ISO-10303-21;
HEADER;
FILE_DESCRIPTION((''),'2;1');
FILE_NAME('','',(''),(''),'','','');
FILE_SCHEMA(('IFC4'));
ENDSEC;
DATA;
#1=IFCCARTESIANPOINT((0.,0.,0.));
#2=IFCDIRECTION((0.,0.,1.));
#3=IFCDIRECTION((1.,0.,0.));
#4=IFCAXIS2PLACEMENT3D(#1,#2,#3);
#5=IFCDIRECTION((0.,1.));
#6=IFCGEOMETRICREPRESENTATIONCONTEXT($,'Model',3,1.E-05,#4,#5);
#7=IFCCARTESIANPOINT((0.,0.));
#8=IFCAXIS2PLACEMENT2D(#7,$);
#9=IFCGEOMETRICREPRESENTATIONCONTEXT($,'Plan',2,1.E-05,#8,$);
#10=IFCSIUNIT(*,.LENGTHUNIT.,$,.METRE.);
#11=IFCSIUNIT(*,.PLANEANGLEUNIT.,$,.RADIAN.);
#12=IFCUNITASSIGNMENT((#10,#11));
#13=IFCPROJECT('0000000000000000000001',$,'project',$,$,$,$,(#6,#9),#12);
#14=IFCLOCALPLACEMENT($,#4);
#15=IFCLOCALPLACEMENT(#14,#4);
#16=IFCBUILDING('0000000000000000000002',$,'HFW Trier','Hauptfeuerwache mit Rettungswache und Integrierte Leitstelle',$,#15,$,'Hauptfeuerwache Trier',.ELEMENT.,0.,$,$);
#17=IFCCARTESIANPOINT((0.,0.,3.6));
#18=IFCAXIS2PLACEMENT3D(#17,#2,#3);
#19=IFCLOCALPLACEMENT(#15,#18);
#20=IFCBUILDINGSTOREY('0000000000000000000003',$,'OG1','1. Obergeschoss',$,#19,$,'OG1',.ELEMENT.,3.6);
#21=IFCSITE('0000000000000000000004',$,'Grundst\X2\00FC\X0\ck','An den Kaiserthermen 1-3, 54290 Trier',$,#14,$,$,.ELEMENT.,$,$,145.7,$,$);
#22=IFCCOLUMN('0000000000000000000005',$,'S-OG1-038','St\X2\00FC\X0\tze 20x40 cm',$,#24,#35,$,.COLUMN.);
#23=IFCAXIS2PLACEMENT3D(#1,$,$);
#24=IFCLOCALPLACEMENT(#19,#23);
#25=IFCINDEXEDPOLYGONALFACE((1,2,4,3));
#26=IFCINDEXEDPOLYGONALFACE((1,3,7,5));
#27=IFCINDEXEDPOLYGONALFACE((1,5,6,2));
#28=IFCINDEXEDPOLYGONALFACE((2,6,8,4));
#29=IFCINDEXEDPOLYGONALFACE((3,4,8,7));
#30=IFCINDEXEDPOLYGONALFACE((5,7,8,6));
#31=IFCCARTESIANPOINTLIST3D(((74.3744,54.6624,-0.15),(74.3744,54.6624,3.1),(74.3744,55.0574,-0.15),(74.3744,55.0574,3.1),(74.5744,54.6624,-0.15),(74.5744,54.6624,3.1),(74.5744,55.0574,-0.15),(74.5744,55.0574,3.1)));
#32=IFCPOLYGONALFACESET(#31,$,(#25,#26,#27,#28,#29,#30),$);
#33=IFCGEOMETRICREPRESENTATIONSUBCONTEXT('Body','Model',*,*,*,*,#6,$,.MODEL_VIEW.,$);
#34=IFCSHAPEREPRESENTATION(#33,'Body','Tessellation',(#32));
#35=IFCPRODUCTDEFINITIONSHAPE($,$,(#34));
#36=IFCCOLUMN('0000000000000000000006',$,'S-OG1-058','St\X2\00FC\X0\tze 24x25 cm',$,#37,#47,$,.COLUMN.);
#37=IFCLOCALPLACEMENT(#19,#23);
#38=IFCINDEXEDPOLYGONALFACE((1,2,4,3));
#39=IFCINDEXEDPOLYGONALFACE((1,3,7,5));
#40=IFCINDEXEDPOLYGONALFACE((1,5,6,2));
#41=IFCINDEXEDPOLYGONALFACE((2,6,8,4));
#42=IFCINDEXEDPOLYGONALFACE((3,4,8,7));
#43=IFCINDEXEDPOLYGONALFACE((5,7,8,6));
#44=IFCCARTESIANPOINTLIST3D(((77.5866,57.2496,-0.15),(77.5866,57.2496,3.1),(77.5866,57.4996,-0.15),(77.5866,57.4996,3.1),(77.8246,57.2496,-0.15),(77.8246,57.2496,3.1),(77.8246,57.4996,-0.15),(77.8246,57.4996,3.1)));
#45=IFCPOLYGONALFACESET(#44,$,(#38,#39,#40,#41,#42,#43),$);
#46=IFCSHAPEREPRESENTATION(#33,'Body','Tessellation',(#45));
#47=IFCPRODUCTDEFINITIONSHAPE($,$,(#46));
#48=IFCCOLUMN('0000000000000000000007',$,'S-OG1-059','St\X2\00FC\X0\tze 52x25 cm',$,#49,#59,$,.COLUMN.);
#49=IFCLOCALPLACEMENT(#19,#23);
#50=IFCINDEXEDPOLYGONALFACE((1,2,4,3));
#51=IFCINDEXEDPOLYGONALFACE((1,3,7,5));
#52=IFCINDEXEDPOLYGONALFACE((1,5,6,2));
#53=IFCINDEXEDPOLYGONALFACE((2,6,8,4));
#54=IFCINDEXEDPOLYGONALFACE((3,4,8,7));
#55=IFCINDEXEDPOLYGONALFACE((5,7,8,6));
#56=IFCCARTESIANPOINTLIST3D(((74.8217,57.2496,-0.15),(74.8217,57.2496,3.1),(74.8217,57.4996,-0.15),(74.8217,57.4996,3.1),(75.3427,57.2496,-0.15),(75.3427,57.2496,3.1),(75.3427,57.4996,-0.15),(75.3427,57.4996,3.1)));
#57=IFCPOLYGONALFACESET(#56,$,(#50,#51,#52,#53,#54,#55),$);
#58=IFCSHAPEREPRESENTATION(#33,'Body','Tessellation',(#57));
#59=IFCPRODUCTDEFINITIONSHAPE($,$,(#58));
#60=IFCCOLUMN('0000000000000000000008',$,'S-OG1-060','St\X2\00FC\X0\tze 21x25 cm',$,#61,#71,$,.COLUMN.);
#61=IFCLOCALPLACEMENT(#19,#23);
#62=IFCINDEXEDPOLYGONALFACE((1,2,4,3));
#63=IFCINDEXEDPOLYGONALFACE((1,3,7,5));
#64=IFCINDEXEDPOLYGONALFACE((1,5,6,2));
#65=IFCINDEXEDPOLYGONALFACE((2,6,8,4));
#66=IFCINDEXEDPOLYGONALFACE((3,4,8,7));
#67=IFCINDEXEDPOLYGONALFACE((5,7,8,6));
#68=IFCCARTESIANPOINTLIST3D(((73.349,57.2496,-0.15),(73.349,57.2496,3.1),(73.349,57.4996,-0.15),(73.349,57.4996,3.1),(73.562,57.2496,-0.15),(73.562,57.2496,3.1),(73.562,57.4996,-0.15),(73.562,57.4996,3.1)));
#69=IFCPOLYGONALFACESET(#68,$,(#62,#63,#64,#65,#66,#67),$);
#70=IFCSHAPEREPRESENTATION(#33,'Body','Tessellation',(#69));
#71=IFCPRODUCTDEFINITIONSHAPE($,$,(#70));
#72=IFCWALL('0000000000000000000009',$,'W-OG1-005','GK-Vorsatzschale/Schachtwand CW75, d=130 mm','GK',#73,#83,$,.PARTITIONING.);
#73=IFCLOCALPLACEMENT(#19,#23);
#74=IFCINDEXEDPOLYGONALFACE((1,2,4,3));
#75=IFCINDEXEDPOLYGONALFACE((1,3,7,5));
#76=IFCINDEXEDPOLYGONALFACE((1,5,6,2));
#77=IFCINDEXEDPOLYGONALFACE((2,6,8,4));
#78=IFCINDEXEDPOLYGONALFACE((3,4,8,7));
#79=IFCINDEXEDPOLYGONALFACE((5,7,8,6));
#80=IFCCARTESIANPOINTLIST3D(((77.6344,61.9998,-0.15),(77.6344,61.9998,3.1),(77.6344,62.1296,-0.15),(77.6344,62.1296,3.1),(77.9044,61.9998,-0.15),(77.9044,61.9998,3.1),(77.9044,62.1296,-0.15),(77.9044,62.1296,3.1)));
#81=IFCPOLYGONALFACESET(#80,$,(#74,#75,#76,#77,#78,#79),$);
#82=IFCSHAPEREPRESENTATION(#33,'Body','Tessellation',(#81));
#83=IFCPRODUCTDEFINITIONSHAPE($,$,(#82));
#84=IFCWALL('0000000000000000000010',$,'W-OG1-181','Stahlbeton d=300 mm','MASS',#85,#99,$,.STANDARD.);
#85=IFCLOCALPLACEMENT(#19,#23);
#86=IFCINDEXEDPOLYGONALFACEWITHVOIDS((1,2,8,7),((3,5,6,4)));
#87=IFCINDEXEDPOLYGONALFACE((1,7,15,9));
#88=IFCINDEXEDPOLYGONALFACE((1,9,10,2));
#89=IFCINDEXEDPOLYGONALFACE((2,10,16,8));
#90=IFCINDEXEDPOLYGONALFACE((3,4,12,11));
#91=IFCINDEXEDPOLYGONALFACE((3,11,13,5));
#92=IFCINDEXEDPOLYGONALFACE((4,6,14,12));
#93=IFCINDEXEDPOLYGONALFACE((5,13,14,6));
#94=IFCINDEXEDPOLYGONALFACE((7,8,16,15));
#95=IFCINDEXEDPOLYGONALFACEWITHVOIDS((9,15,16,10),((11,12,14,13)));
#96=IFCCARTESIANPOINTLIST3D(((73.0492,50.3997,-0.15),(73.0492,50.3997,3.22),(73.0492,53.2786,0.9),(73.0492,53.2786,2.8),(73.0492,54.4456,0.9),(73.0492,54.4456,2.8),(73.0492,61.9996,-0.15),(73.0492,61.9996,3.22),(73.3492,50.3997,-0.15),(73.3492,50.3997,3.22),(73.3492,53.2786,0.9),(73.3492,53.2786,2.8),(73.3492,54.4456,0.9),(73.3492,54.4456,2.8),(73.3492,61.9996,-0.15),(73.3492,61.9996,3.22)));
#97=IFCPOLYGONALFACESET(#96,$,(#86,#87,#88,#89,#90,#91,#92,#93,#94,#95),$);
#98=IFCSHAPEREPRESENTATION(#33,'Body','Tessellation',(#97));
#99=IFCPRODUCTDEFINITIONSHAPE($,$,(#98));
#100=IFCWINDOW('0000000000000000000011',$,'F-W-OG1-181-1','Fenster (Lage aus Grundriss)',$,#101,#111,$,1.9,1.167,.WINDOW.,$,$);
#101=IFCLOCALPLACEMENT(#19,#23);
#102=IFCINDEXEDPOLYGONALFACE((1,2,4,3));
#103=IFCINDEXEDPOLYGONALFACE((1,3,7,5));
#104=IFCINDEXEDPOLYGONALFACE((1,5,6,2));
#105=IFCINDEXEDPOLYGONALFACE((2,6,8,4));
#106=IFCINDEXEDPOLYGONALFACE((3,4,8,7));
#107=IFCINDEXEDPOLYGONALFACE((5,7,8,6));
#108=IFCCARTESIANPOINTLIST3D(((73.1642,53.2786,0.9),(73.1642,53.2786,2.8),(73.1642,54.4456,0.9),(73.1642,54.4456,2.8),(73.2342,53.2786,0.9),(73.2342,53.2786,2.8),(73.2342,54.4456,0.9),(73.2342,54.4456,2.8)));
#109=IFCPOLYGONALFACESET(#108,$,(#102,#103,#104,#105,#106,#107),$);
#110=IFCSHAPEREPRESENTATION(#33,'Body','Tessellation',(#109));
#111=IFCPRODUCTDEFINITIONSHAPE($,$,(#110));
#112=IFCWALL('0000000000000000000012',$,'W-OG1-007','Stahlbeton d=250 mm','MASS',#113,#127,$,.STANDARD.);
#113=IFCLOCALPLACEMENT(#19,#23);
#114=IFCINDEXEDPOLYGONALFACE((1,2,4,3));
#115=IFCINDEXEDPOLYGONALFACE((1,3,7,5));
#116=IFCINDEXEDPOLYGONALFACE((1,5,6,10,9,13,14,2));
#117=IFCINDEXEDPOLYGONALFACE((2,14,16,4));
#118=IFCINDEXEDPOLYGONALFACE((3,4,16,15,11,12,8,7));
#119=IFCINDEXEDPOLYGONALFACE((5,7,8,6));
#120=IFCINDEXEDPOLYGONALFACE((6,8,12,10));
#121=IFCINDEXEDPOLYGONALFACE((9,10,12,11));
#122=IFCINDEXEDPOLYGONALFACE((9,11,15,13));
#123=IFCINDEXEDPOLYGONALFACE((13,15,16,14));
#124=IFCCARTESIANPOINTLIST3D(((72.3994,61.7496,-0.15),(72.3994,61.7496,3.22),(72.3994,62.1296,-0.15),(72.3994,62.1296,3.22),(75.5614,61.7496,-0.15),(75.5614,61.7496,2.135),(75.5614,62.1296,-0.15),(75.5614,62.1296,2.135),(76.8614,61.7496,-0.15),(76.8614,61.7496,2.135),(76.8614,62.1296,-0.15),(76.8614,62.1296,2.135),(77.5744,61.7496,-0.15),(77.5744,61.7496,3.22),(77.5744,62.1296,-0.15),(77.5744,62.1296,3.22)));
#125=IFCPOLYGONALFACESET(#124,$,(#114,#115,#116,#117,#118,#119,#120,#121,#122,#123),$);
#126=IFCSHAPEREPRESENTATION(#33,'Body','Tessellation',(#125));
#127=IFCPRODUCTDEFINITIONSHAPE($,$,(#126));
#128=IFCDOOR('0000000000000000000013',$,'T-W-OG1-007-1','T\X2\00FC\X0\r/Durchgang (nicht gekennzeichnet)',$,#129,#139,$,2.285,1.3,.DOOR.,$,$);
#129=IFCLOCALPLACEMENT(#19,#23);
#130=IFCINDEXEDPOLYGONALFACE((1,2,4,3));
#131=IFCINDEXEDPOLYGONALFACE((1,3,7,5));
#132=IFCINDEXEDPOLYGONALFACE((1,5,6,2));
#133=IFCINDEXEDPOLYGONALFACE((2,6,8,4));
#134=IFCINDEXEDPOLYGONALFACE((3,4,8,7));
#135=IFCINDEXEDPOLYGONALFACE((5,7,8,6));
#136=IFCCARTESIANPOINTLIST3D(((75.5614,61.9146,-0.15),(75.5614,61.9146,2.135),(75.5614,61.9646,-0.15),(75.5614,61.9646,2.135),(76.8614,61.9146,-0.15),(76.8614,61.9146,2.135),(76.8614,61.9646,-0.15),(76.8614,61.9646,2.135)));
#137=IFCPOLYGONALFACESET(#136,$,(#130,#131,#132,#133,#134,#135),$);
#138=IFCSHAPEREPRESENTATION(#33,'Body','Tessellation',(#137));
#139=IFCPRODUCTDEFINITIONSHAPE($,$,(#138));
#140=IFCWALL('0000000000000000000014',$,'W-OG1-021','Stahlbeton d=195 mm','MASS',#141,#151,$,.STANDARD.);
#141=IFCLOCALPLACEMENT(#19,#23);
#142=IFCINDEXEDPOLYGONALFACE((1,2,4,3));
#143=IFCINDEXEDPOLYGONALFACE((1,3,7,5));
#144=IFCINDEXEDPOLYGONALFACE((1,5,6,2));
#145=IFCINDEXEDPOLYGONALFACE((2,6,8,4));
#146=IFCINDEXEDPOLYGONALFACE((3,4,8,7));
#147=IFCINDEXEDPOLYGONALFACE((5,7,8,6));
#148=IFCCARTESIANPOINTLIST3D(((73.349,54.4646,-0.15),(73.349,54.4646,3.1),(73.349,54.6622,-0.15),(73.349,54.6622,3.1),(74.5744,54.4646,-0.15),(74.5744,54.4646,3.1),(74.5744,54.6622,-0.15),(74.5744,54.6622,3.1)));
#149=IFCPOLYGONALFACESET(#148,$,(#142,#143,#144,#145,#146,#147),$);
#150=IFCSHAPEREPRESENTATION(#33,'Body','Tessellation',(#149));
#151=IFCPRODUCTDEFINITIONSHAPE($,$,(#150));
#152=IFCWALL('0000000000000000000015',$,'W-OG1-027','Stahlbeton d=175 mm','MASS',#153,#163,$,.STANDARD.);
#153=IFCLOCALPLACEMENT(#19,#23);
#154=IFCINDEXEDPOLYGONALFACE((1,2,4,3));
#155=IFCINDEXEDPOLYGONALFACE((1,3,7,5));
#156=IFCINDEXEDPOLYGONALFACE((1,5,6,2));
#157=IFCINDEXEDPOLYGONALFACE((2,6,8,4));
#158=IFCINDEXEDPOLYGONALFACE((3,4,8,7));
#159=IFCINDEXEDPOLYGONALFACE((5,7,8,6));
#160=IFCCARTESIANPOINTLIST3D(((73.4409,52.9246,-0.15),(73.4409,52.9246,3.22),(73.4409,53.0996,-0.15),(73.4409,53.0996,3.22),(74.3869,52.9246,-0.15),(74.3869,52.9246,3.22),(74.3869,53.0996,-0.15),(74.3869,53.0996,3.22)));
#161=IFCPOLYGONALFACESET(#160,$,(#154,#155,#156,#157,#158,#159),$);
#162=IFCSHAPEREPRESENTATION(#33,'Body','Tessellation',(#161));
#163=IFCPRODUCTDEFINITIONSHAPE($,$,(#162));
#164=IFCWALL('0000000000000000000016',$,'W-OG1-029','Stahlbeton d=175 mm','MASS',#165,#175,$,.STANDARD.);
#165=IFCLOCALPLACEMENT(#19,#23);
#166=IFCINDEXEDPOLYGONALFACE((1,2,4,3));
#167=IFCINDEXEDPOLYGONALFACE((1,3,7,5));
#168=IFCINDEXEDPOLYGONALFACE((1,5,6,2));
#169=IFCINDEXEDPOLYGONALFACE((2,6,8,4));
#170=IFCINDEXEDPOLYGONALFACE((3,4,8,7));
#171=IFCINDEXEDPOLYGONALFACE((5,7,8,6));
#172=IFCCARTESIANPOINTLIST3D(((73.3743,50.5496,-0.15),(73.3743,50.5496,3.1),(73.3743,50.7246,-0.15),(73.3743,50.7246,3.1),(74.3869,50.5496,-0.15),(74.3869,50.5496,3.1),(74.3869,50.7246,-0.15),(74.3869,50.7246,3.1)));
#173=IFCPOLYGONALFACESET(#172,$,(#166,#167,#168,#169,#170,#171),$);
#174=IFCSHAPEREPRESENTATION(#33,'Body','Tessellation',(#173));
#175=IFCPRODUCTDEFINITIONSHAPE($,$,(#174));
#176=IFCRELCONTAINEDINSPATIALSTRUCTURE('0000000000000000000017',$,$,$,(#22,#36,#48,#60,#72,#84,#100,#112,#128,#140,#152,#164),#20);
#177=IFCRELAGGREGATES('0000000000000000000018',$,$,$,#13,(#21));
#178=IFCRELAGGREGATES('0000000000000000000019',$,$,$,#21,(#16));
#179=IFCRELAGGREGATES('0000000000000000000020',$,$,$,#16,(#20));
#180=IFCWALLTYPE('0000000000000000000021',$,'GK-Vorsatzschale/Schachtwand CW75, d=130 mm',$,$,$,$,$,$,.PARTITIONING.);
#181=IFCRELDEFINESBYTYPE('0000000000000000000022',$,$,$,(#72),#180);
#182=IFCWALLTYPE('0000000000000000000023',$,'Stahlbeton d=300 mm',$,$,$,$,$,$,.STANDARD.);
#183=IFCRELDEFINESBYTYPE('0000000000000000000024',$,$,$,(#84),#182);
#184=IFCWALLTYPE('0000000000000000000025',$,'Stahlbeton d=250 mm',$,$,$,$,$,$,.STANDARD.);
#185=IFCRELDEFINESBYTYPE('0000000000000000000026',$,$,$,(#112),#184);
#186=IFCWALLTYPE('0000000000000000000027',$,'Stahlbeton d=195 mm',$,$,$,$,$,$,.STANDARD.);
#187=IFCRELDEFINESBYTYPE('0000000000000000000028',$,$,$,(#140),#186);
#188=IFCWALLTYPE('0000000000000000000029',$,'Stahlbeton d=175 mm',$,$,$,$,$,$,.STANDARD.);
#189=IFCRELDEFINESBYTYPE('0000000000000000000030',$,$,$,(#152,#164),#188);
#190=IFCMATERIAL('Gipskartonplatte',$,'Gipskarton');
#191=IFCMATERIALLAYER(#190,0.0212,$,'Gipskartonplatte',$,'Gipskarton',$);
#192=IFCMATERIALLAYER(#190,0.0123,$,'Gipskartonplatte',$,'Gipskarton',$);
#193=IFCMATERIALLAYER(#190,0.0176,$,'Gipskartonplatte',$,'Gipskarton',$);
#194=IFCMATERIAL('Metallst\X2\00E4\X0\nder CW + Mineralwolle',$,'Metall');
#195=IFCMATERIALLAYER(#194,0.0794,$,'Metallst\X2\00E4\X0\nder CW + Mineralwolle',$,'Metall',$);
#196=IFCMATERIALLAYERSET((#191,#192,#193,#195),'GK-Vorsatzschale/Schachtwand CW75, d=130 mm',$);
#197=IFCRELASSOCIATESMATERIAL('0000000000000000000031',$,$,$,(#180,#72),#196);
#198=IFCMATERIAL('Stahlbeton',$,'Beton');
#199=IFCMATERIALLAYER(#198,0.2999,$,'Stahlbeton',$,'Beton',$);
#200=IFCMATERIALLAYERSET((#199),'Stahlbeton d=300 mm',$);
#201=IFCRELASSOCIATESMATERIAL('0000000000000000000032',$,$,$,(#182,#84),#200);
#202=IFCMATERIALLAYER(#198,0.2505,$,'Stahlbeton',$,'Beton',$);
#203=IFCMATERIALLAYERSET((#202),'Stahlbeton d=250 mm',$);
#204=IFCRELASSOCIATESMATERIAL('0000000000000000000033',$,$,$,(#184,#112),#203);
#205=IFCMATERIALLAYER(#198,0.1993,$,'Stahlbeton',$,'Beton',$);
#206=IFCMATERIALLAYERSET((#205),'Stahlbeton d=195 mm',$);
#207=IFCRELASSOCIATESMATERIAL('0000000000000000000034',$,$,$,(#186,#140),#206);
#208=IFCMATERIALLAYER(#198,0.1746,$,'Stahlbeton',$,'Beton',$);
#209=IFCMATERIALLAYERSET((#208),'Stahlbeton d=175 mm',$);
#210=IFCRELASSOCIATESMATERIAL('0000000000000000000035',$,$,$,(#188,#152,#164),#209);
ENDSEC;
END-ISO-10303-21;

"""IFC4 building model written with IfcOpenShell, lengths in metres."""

from ifc_helpers import new_model, si_unit, direction, frame, frame_2d, origin_with_axes, origin_2d, place, context, subcontext, project, spatial, rectangle, extrude, material, layer, layer_set, layer_usage, type_object, element, fill, save


model = new_model("IFC4")

# Units and contexts
model_context = context("Model", 3, precision=1e-05, world=origin_with_axes(), true_north=direction((0.0, 1.0)))
plan_context = context("Plan", 2, precision=1e-05, world=origin_2d())
body_context = subcontext(model_context, "Body", "Model", "MODEL_VIEW")
ifc_project = project(units=[si_unit("LENGTHUNIT", "METRE"), si_unit("PLANEANGLEUNIT", "RADIAN")], contexts=[model_context, plan_context])

# Site, building, storey
site_placement = place(None, origin_with_axes())
site = spatial("IfcSite", under=ifc_project, at=site_placement, Name="Grundstück", Description="An den Kaiserthermen 1-3, 54290 Trier", CompositionType="ELEMENT", RefElevation=145.7)
building_placement = place(site_placement, origin_with_axes())
building = spatial("IfcBuilding", under=site, at=building_placement, Name="HFW Trier", Description="Hauptfeuerwache mit Rettungswache und Integrierte Leitstelle", LongName="Hauptfeuerwache Trier", CompositionType="ELEMENT", ElevationOfRefHeight=0.0)
storey_placement = place(building_placement, frame((0.0, 0.0, 3.6), z_axis=(0.0, 0.0, 1.0), x_axis=(1.0, 0.0, 0.0)))
storey = spatial("IfcBuildingStorey", under=building, at=storey_placement, Name="OG1", Description="1. Obergeschoss", LongName="OG1", CompositionType="ELEMENT", Elevation=3.6)

# Columns
column_1_placement = place(storey_placement, frame((74.3744, 54.8599, -0.15), z_axis=(0.0, 0.0, 1.0), x_axis=(1.0, 0.0, 0.0)))
element("IfcColumn", 1, at=column_1_placement, inside=storey, Name="S-OG1-038", Description="Stütze 20x40 cm", PredefinedType="COLUMN", context=body_context, shape_type="SweptSolid", body=[
    extrude(rectangle(XDim=0.2, YDim=0.395, at=frame_2d((0.1, 0.0))), origin_with_axes(), (0.0, 0.0, 1.0), 3.25),
])
column_2_placement = place(storey_placement, frame((77.5866, 57.3746, -0.15), z_axis=(0.0, 0.0, 1.0), x_axis=(1.0, 0.0, 0.0)))
element("IfcColumn", 2, at=column_2_placement, inside=storey, Name="S-OG1-058", Description="Stütze 24x25 cm", PredefinedType="COLUMN", context=body_context, shape_type="SweptSolid", body=[
    extrude(rectangle(XDim=0.238, YDim=0.25, at=frame_2d((0.119, 0.0))), origin_with_axes(), (0.0, 0.0, 1.0), 3.25),
])
column_3_placement = place(storey_placement, frame((74.8217, 57.3746, -0.15), z_axis=(0.0, 0.0, 1.0), x_axis=(1.0, 0.0, 0.0)))
element("IfcColumn", 3, at=column_3_placement, inside=storey, Name="S-OG1-059", Description="Stütze 52x25 cm", PredefinedType="COLUMN", context=body_context, shape_type="SweptSolid", body=[
    extrude(rectangle(XDim=0.521, YDim=0.25, at=frame_2d((0.2605, 0.0))), origin_with_axes(), (0.0, 0.0, 1.0), 3.25),
])
column_4_placement = place(storey_placement, frame((73.349, 57.3746, -0.15), z_axis=(0.0, 0.0, 1.0), x_axis=(1.0, 0.0, 0.0)))
element("IfcColumn", 4, at=column_4_placement, inside=storey, Name="S-OG1-060", Description="Stütze 21x25 cm", PredefinedType="COLUMN", context=body_context, shape_type="SweptSolid", body=[
    extrude(rectangle(XDim=0.213, YDim=0.25, at=frame_2d((0.1065, 0.0))), origin_with_axes(), (0.0, 0.0, 1.0), 3.25),
])

# Wall
ifc_material_1 = material(Name="Gipskartonplatte", Category="Gipskarton")
ifc_layer_1 = layer(ifc_material_1, 0.0212, Name="Gipskartonplatte", Category="Gipskarton")
ifc_layer_2 = layer(ifc_material_1, 0.0123, Name="Gipskartonplatte", Category="Gipskarton")
ifc_layer_3 = layer(ifc_material_1, 0.0176, Name="Gipskartonplatte", Category="Gipskarton")
ifc_material_2 = material(Name="Metallständer CW + Mineralwolle", Category="Metall")
ifc_layer_4 = layer(ifc_material_2, 0.0794, Name="Metallständer CW + Mineralwolle", Category="Metall")
ifc_layer_set_1 = layer_set([ifc_layer_1, ifc_layer_2, ifc_layer_3, ifc_layer_4], Name="GK-Vorsatzschale/Schachtwand CW75, d=130 mm")
ifc_layer_usage_1 = layer_usage(ifc_layer_set_1, "AXIS2", "POSITIVE", -0.0649)
wall_type_1 = type_object("IfcWallType", Name="GK-Vorsatzschale/Schachtwand CW75, d=130 mm", PredefinedType="PARTITIONING", material=ifc_layer_set_1)
wall_1_placement = place(storey_placement, frame((77.6344, 62.0647, -0.15), z_axis=(0.0, 0.0, 1.0), x_axis=(1.0, 0.0, 0.0)))
element("IfcWall", 5, at=wall_1_placement, inside=storey, type_object=wall_type_1, material=ifc_layer_usage_1, Name="W-OG1-005", Description="GK-Vorsatzschale/Schachtwand CW75, d=130 mm", ObjectType="GK", PredefinedType="PARTITIONING", context=body_context, shape_type="SweptSolid", body=[
    extrude(rectangle(XDim=0.27, YDim=0.1298, at=frame_2d((0.135, 0.0))), origin_with_axes(), (0.0, 0.0, 1.0), 3.25),
])

# Wall, opening, window
ifc_material_3 = material(Name="Stahlbeton", Category="Beton")
ifc_layer_5 = layer(ifc_material_3, 0.2999, Name="Stahlbeton", Category="Beton")
ifc_layer_set_2 = layer_set([ifc_layer_5], Name="Stahlbeton d=300 mm")
ifc_layer_usage_2 = layer_usage(ifc_layer_set_2, "AXIS2", "POSITIVE", -0.15)
wall_type_2 = type_object("IfcWallType", Name="Stahlbeton d=300 mm", PredefinedType="STANDARD", material=ifc_layer_set_2)
wall_2_placement = place(storey_placement, frame((73.1992, 61.9996, -0.15), z_axis=(0.0, 0.0, 1.0), x_axis=(0.0, -1.0, 0.0)))
wall_2 = element("IfcWall", 6, at=wall_2_placement, inside=storey, type_object=wall_type_2, material=ifc_layer_usage_2, Name="W-OG1-181", Description="Stahlbeton d=300 mm", ObjectType="MASS", PredefinedType="STANDARD", context=body_context, shape_type="SweptSolid", body=[
    extrude(rectangle(XDim=11.5999, YDim=0.3, at=frame_2d((5.7999, 0.0))), origin_with_axes(), (0.0, 0.0, 1.0), 3.37),
])
opening_1_placement = place(wall_2_placement, frame((7.554, 0.0, 0.0), z_axis=(0.0, 0.0, 1.0), x_axis=(1.0, 0.0, 0.0)))
opening_1 = element("IfcOpeningElement", 7, at=opening_1_placement, cuts=wall_2, PredefinedType="OPENING", context=body_context, shape_type="SweptSolid", body=[
    extrude(rectangle(XDim=1.167, YDim=0.4, at=frame_2d((0.5835, 0.0))), frame((0.0, 0.0, 1.05), z_axis=(0.0, 0.0, 1.0), x_axis=(1.0, 0.0, 0.0)), (0.0, 0.0, 1.0), 1.9),
])
window_placement = place(wall_2_placement, frame((7.554, 0.0, 0.0), z_axis=(0.0, 0.0, 1.0), x_axis=(1.0, 0.0, 0.0)))
window = element("IfcWindow", 8, at=window_placement, inside=storey, Name="F-W-OG1-181-1", Description="Fenster (Lage aus Grundriss)", OverallHeight=1.9, OverallWidth=1.167, PredefinedType="WINDOW", context=body_context, shape_type="SweptSolid", body=[
    extrude(rectangle(XDim=1.167, YDim=0.07, at=frame_2d((0.5835, 0.0))), frame((0.0, 0.0, 1.05), z_axis=(0.0, 0.0, 1.0), x_axis=(1.0, 0.0, 0.0)), (0.0, 0.0, 1.0), 1.9),
])
fill(opening_1, window)

# Wall, opening, door
ifc_layer_6 = layer(ifc_material_3, 0.2505, Name="Stahlbeton", Category="Beton")
ifc_layer_set_3 = layer_set([ifc_layer_6], Name="Stahlbeton d=250 mm")
ifc_layer_usage_3 = layer_usage(ifc_layer_set_3, "AXIS2", "POSITIVE", -0.19)
wall_type_3 = type_object("IfcWallType", Name="Stahlbeton d=250 mm", PredefinedType="STANDARD", material=ifc_layer_set_3)
wall_3_placement = place(storey_placement, frame((72.3994, 61.9396, -0.15), z_axis=(0.0, 0.0, 1.0), x_axis=(1.0, 0.0, 0.0)))
wall_3 = element("IfcWall", 9, at=wall_3_placement, inside=storey, type_object=wall_type_3, material=ifc_layer_usage_3, Name="W-OG1-007", Description="Stahlbeton d=250 mm", ObjectType="MASS", PredefinedType="STANDARD", context=body_context, shape_type="SweptSolid", body=[
    extrude(rectangle(XDim=5.175, YDim=0.38, at=frame_2d((2.5875, 0.0))), origin_with_axes(), (0.0, 0.0, 1.0), 3.37),
])
opening_2_placement = place(wall_3_placement, frame((3.162, 0.0, 0.0), z_axis=(0.0, 0.0, 1.0), x_axis=(1.0, 0.0, 0.0)))
opening_2 = element("IfcOpeningElement", 10, at=opening_2_placement, cuts=wall_3, PredefinedType="OPENING", context=body_context, shape_type="SweptSolid", body=[
    extrude(rectangle(XDim=1.3, YDim=0.48, at=frame_2d((0.65, 0.0))), origin_with_axes(), (0.0, 0.0, 1.0), 2.285),
])
door_placement = place(wall_3_placement, frame((3.162, 0.0, 0.0), z_axis=(0.0, 0.0, 1.0), x_axis=(1.0, 0.0, 0.0)))
door = element("IfcDoor", 11, at=door_placement, inside=storey, Name="T-W-OG1-007-1", Description="Tür/Durchgang (nicht gekennzeichnet)", OverallHeight=2.285, OverallWidth=1.3, PredefinedType="DOOR", context=body_context, shape_type="SweptSolid", body=[
    extrude(rectangle(XDim=1.3, YDim=0.05, at=frame_2d((0.65, 0.0))), origin_with_axes(), (0.0, 0.0, 1.0), 2.285),
])
fill(opening_2, door)

# Walls
ifc_layer_7 = layer(ifc_material_3, 0.1993, Name="Stahlbeton", Category="Beton")
ifc_layer_set_4 = layer_set([ifc_layer_7], Name="Stahlbeton d=195 mm")
ifc_layer_usage_4 = layer_usage(ifc_layer_set_4, "AXIS2", "POSITIVE", -0.0988)
wall_type_4 = type_object("IfcWallType", Name="Stahlbeton d=195 mm", PredefinedType="STANDARD", material=ifc_layer_set_4)
wall_4_placement = place(storey_placement, frame((73.349, 54.5634, -0.15), z_axis=(0.0, 0.0, 1.0), x_axis=(1.0, 0.0, 0.0)))
element("IfcWall", 12, at=wall_4_placement, inside=storey, type_object=wall_type_4, material=ifc_layer_usage_4, Name="W-OG1-021", Description="Stahlbeton d=195 mm", ObjectType="MASS", PredefinedType="STANDARD", context=body_context, shape_type="SweptSolid", body=[
    extrude(rectangle(XDim=1.2254, YDim=0.1975, at=frame_2d((0.6127, 0.0))), origin_with_axes(), (0.0, 0.0, 1.0), 3.25),
])
ifc_layer_8 = layer(ifc_material_3, 0.1746, Name="Stahlbeton", Category="Beton")
ifc_layer_set_5 = layer_set([ifc_layer_8], Name="Stahlbeton d=175 mm")
ifc_layer_usage_5 = layer_usage(ifc_layer_set_5, "AXIS2", "POSITIVE", -0.0875)
wall_type_5 = type_object("IfcWallType", Name="Stahlbeton d=175 mm", PredefinedType="STANDARD", material=ifc_layer_set_5)
wall_5_placement = place(storey_placement, frame((73.4409, 53.0121, -0.15), z_axis=(0.0, 0.0, 1.0), x_axis=(1.0, 0.0, 0.0)))
element("IfcWall", 13, at=wall_5_placement, inside=storey, type_object=wall_type_5, material=ifc_layer_usage_5, Name="W-OG1-027", Description="Stahlbeton d=175 mm", ObjectType="MASS", PredefinedType="STANDARD", context=body_context, shape_type="SweptSolid", body=[
    extrude(rectangle(XDim=0.946, YDim=0.175, at=frame_2d((0.473, 0.0))), origin_with_axes(), (0.0, 0.0, 1.0), 3.37),
])
ifc_layer_usage_6 = layer_usage(ifc_layer_set_5, "AXIS2", "POSITIVE", -0.0875)
wall_6_placement = place(storey_placement, frame((73.3743, 50.6371, -0.15), z_axis=(0.0, 0.0, 1.0), x_axis=(1.0, 0.0, 0.0)))
element("IfcWall", 14, at=wall_6_placement, inside=storey, type_object=wall_type_5, material=ifc_layer_usage_6, Name="W-OG1-029", Description="Stahlbeton d=175 mm", ObjectType="MASS", PredefinedType="STANDARD", context=body_context, shape_type="SweptSolid", body=[
    extrude(rectangle(XDim=1.0126, YDim=0.175, at=frame_2d((0.5063, 0.0))), origin_with_axes(), (0.0, 0.0, 1.0), 3.25),
])

save(model, "model.ifc")
